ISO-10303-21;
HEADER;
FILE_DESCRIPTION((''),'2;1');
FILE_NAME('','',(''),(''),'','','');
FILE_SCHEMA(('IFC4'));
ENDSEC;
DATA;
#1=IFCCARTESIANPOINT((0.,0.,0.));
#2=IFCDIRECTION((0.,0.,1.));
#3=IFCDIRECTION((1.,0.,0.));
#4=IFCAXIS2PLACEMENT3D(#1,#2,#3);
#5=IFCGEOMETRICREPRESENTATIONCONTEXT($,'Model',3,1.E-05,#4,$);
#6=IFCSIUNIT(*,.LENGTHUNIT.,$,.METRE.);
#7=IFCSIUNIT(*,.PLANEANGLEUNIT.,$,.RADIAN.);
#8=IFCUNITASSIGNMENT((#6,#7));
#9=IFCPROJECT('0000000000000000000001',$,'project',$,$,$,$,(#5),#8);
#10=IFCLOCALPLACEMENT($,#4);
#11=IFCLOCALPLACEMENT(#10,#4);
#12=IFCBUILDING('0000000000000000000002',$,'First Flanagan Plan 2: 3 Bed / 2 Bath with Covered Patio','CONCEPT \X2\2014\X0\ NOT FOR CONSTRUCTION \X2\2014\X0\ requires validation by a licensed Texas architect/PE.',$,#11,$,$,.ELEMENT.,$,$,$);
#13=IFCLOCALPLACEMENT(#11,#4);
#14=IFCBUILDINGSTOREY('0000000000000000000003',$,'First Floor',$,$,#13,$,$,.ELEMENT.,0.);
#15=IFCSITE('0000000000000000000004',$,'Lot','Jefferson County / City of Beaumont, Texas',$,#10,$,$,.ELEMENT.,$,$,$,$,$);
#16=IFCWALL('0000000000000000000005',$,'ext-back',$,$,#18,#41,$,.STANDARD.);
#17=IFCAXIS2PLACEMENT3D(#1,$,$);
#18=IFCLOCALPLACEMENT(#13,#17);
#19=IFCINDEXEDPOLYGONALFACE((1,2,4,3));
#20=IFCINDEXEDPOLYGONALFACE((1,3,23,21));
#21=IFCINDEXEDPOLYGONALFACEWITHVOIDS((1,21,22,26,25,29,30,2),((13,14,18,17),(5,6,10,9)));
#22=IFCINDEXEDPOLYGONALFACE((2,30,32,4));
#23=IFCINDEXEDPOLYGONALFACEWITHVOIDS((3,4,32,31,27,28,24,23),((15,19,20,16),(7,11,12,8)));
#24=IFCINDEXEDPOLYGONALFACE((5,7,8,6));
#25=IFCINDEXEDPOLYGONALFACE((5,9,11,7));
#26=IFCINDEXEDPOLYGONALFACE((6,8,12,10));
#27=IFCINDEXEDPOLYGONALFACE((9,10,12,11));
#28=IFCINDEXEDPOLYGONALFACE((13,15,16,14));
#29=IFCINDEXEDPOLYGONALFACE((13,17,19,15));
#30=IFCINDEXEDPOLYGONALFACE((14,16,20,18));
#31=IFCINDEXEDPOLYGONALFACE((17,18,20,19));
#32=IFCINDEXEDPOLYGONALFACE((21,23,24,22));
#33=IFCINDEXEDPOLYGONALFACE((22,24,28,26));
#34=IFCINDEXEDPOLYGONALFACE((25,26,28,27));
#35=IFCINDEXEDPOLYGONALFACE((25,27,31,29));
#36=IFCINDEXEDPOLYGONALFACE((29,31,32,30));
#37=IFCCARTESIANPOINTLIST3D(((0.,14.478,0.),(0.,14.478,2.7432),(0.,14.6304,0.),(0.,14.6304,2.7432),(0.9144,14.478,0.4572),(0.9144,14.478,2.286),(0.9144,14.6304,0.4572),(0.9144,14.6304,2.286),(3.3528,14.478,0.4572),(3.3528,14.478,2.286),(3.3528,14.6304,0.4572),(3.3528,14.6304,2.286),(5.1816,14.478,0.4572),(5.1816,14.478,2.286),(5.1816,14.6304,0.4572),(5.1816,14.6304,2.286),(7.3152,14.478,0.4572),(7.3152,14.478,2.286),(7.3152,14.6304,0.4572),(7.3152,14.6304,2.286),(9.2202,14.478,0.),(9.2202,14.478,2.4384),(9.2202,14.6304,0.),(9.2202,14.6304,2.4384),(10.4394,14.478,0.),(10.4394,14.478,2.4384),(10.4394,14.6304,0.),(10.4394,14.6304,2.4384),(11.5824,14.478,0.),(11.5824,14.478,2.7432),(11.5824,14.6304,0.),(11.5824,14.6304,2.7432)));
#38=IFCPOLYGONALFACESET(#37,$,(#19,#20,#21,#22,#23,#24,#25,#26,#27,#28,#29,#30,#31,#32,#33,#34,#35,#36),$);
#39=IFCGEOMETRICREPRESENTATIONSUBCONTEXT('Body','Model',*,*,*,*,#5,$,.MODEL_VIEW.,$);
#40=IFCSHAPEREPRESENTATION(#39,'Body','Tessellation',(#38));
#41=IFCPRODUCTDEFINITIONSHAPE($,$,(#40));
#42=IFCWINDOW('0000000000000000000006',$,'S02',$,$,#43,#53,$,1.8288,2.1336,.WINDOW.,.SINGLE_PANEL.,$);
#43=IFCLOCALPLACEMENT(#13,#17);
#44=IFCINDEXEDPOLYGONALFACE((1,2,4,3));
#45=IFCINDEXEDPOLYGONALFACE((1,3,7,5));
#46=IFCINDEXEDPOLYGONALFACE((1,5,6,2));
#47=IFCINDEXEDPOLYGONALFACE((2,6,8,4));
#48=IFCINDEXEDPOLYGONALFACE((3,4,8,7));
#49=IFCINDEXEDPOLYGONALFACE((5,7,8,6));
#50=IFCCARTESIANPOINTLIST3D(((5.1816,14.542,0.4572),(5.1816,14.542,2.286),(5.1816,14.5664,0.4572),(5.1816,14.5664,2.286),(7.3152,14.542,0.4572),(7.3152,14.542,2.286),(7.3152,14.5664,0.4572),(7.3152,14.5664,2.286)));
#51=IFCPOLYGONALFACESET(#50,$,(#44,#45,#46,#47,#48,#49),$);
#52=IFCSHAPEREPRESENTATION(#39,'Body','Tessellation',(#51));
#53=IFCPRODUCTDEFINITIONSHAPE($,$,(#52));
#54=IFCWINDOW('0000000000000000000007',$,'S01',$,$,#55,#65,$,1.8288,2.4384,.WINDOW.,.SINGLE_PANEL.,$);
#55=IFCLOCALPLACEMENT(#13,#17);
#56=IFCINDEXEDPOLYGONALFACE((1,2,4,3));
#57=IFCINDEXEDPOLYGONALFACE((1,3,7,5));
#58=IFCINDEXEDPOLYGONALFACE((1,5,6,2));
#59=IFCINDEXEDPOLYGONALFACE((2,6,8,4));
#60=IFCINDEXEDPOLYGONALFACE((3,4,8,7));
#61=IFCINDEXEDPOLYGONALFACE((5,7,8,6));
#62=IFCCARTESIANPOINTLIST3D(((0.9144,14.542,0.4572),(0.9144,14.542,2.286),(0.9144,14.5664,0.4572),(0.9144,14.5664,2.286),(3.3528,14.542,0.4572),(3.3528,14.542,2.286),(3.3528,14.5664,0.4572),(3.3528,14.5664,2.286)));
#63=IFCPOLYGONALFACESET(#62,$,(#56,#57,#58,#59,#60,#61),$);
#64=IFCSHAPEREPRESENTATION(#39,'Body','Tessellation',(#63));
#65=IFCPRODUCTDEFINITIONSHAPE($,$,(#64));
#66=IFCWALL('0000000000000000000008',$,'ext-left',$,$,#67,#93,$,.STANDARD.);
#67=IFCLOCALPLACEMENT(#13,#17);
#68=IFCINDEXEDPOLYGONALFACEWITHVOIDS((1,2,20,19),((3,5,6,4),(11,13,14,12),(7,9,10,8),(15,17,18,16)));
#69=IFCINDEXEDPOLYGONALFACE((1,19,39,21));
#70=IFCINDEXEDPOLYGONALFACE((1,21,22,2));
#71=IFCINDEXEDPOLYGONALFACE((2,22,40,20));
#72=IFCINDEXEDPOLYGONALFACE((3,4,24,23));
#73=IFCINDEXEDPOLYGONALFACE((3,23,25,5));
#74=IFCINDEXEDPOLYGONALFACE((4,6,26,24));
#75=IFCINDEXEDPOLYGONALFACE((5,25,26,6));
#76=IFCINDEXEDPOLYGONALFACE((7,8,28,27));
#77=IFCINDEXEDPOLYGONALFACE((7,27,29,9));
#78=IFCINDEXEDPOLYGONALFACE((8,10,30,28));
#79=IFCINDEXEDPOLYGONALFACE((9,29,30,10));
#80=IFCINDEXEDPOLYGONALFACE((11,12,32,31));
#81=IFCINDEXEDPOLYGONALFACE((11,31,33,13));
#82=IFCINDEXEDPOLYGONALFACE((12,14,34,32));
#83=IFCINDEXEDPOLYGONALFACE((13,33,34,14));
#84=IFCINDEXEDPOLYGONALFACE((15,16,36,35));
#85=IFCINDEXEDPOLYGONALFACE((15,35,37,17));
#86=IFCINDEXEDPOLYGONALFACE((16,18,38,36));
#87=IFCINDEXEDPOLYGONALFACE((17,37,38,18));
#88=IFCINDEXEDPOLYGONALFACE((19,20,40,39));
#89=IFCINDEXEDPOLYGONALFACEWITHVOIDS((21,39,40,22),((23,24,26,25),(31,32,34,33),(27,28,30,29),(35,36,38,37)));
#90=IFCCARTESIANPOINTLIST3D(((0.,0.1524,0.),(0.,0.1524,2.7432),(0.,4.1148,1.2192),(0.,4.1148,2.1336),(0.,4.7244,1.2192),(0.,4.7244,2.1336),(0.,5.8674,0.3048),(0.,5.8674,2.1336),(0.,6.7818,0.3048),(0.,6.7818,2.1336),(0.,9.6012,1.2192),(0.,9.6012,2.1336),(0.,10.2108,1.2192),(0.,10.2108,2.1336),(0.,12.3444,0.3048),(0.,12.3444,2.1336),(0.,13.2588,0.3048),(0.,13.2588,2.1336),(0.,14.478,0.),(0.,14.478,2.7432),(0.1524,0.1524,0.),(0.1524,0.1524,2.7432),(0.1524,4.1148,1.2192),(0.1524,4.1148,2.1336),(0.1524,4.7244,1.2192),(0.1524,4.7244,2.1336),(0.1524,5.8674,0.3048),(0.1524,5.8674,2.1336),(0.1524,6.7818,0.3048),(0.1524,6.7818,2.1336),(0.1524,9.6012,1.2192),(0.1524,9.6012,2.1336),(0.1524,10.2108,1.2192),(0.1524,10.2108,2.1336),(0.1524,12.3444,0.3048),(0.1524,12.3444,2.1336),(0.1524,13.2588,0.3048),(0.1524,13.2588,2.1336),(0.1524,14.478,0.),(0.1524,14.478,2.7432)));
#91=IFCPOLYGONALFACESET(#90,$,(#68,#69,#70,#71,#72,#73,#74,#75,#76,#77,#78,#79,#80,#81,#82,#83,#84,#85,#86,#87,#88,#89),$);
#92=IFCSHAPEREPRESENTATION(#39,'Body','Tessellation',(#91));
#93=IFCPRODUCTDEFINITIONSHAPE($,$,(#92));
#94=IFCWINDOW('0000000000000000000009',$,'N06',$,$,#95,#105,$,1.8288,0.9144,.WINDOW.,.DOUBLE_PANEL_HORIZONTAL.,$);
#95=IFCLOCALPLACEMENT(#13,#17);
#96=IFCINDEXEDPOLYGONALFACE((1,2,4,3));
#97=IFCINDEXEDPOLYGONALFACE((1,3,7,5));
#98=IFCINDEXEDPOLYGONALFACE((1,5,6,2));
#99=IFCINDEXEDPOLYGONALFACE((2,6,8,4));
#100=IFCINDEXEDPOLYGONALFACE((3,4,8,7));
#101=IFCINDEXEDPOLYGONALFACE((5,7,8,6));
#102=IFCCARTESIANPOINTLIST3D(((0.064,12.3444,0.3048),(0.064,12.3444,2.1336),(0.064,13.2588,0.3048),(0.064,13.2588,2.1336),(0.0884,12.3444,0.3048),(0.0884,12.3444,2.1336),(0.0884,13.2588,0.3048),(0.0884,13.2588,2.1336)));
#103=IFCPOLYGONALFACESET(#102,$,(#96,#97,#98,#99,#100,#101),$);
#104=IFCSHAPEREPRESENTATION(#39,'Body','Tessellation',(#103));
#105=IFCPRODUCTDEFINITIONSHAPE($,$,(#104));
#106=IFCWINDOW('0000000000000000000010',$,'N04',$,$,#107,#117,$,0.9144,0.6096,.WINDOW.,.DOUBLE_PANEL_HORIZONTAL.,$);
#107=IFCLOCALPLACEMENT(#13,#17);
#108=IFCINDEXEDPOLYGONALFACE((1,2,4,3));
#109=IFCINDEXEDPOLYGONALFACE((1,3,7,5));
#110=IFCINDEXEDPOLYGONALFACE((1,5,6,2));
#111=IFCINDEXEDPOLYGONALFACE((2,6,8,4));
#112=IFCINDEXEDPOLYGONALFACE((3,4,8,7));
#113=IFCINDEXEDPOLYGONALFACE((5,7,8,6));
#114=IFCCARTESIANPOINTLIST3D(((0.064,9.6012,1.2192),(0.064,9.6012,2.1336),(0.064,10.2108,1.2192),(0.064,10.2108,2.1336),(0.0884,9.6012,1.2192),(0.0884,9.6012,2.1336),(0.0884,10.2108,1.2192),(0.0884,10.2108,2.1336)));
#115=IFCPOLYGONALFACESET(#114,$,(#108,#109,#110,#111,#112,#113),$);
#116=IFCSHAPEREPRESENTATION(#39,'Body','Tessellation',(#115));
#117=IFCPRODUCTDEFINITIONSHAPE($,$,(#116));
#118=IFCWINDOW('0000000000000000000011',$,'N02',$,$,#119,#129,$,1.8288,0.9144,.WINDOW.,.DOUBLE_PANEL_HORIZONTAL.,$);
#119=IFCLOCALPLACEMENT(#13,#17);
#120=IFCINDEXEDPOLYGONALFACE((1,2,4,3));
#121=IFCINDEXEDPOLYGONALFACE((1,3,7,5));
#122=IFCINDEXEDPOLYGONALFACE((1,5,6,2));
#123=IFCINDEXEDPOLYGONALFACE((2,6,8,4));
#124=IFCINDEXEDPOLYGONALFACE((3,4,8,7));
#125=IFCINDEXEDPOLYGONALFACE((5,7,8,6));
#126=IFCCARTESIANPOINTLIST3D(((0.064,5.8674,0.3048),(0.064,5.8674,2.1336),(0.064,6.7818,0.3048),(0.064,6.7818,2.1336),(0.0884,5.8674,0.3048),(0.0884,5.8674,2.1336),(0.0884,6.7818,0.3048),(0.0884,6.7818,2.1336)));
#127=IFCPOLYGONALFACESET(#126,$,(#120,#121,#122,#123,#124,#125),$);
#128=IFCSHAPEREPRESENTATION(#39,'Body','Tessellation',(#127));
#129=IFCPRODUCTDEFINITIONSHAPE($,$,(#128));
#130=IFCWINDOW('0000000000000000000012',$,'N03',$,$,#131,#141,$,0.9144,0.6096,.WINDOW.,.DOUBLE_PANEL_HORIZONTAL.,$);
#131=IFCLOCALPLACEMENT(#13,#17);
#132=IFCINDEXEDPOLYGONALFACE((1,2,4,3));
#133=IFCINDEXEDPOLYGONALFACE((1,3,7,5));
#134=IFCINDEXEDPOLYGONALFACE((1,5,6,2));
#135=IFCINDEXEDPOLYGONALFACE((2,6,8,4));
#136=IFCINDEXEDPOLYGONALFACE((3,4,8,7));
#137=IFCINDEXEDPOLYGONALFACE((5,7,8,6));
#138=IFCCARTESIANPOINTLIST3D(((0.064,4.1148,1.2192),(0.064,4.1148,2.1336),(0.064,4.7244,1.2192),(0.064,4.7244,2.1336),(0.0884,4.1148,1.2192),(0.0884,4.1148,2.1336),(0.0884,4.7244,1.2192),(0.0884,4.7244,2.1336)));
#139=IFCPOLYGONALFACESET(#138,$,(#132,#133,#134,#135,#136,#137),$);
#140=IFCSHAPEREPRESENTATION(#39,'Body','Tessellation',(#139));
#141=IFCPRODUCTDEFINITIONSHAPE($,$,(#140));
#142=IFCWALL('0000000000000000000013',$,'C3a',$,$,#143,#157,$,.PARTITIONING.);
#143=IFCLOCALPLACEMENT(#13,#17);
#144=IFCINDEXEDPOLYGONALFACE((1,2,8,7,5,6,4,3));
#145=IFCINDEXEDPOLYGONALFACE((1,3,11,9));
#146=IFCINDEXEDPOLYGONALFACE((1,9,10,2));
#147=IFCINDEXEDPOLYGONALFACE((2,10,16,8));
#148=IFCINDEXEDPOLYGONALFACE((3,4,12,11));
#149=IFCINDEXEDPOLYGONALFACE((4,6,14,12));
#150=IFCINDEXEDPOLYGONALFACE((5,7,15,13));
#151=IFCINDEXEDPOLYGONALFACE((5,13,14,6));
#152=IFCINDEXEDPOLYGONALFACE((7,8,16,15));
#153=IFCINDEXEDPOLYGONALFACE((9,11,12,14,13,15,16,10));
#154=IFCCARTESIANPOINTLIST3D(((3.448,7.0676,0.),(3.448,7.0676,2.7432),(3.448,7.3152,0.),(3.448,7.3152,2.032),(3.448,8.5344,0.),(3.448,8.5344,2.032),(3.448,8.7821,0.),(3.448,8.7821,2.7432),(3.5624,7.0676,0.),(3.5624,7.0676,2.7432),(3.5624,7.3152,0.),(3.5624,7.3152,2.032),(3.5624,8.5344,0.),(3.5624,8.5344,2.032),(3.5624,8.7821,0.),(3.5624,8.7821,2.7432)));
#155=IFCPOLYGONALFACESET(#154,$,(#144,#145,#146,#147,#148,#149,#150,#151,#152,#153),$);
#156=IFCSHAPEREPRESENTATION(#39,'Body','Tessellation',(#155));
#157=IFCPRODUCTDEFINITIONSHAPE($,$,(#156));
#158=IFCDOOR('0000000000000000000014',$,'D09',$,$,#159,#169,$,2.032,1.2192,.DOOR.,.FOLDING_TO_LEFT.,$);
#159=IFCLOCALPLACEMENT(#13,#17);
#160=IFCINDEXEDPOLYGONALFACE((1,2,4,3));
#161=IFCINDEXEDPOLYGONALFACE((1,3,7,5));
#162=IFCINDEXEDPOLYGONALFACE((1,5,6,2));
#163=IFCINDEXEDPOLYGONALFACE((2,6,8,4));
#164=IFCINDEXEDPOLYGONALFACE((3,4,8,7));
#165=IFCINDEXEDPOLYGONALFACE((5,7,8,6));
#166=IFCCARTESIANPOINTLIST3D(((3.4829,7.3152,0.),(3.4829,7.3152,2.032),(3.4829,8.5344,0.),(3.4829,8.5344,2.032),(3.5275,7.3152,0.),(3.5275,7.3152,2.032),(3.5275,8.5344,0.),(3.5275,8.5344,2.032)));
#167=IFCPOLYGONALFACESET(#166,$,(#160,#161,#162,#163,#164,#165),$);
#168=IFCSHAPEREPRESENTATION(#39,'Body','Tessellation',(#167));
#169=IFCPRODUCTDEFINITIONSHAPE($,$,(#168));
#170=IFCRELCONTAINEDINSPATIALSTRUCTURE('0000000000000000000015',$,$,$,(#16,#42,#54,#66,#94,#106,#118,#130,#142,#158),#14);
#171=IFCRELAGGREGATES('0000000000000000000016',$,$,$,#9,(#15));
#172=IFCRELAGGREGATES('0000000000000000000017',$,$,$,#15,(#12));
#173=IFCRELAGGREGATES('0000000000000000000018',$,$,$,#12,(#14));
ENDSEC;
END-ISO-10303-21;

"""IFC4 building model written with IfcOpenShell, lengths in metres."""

from ifc_helpers import new_model, si_unit, frame, frame_2d, origin_with_axes, place, context, subcontext, project, spatial, rectangle, extrude, element, fill, save


model = new_model("IFC4")

# Units and contexts
model_context = context("Model", 3, precision=1e-05, world=origin_with_axes())
body_context = subcontext(model_context, "Body", "Model", "MODEL_VIEW")
ifc_project = project(units=[si_unit("LENGTHUNIT", "METRE"), si_unit("PLANEANGLEUNIT", "RADIAN")], contexts=[model_context])

# Site, building, storey
site_placement = place(None, origin_with_axes())
site = spatial("IfcSite", under=ifc_project, at=site_placement, Name="Lot", Description="Jefferson County / City of Beaumont, Texas", CompositionType="ELEMENT")
building_placement = place(site_placement, origin_with_axes())
building = spatial("IfcBuilding", under=site, at=building_placement, Name="First Flanagan Plan 2: 3 Bed / 2 Bath with Covered Patio", Description="CONCEPT — NOT FOR CONSTRUCTION — requires validation by a licensed Texas architect/PE.", CompositionType="ELEMENT")
storey_placement = place(building_placement, origin_with_axes())
storey = spatial("IfcBuildingStorey", under=building, at=storey_placement, Name="First Floor", CompositionType="ELEMENT", Elevation=0.0)

# Walls, openings, windows
wall_1_placement = place(storey_placement, frame((11.5824, 14.5542, 0.0), z_axis=(0.0, 0.0, 1.0), x_axis=(-1.0, 0.0, 0.0)))
wall_1 = element("IfcWall", 1, at=wall_1_placement, inside=storey, Name="ext-back", PredefinedType="STANDARD", context=body_context, shape_type="SweptSolid", body=[
    extrude(rectangle(XDim=11.5824, YDim=0.1524, at=frame_2d((5.7912, 0.0), x_axis=(1.0, 0.0))), origin_with_axes(), (0.0, 0.0, 1.0), 2.7432),
])
opening_1_placement = place(wall_1_placement, frame((1.143, 0.0, 0.0), z_axis=(0.0, 0.0, 1.0), x_axis=(1.0, 0.0, 0.0)))
element("IfcOpeningElement", 2, at=opening_1_placement, cuts=wall_1, PredefinedType="OPENING", context=body_context, shape_type="SweptSolid", body=[
    extrude(rectangle(XDim=1.2192, YDim=0.1829, at=frame_2d((0.6096, 0.0), x_axis=(1.0, 0.0))), origin_with_axes(), (0.0, 0.0, 1.0), 2.4384),
])
opening_2_placement = place(wall_1_placement, frame((4.2672, 0.0, 0.4572), z_axis=(0.0, 0.0, 1.0), x_axis=(1.0, 0.0, 0.0)))
opening_2 = element("IfcOpeningElement", 3, at=opening_2_placement, cuts=wall_1, PredefinedType="OPENING", context=body_context, shape_type="SweptSolid", body=[
    extrude(rectangle(XDim=2.1336, YDim=0.1829, at=frame_2d((1.0668, 0.0), x_axis=(1.0, 0.0))), origin_with_axes(), (0.0, 0.0, 1.0), 1.8288),
])
opening_3_placement = place(wall_1_placement, frame((8.2296, 0.0, 0.4572), z_axis=(0.0, 0.0, 1.0), x_axis=(1.0, 0.0, 0.0)))
opening_3 = element("IfcOpeningElement", 4, at=opening_3_placement, cuts=wall_1, PredefinedType="OPENING", context=body_context, shape_type="SweptSolid", body=[
    extrude(rectangle(XDim=2.4384, YDim=0.1829, at=frame_2d((1.2192, 0.0), x_axis=(1.0, 0.0))), origin_with_axes(), (0.0, 0.0, 1.0), 1.8288),
])
window_1_placement = place(opening_2_placement, origin_with_axes())
window_1 = element("IfcWindow", 5, at=window_1_placement, inside=storey, Name="S02", OverallHeight=1.8288, OverallWidth=2.1336, PartitioningType="SINGLE_PANEL", PredefinedType="WINDOW", context=body_context, shape_type="SweptSolid", body=[
    extrude(rectangle(XDim=2.1336, YDim=0.0244, at=frame_2d((1.0668, 0.0), x_axis=(1.0, 0.0))), origin_with_axes(), (0.0, 0.0, 1.0), 1.8288),
])
fill(opening_2, window_1)
window_2_placement = place(opening_3_placement, origin_with_axes())
window_2 = element("IfcWindow", 6, at=window_2_placement, inside=storey, Name="S01", OverallHeight=1.8288, OverallWidth=2.4384, PartitioningType="SINGLE_PANEL", PredefinedType="WINDOW", context=body_context, shape_type="SweptSolid", body=[
    extrude(rectangle(XDim=2.4384, YDim=0.0244, at=frame_2d((1.2192, 0.0), x_axis=(1.0, 0.0))), origin_with_axes(), (0.0, 0.0, 1.0), 1.8288),
])
fill(opening_3, window_2)
wall_2_placement = place(storey_placement, frame((0.0762, 14.478, 0.0), z_axis=(0.0, 0.0, 1.0), x_axis=(0.0, -1.0, 0.0)))
wall_2 = element("IfcWall", 7, at=wall_2_placement, inside=storey, Name="ext-left", PredefinedType="STANDARD", context=body_context, shape_type="SweptSolid", body=[
    extrude(rectangle(XDim=14.3256, YDim=0.1524, at=frame_2d((7.1628, 0.0), x_axis=(1.0, 0.0))), origin_with_axes(), (0.0, 0.0, 1.0), 2.7432),
])
opening_4_placement = place(wall_2_placement, frame((1.2192, 0.0, 0.3048), z_axis=(0.0, 0.0, 1.0), x_axis=(1.0, 0.0, 0.0)))
opening_4 = element("IfcOpeningElement", 8, at=opening_4_placement, cuts=wall_2, PredefinedType="OPENING", context=body_context, shape_type="SweptSolid", body=[
    extrude(rectangle(XDim=0.9144, YDim=0.1829, at=frame_2d((0.4572, 0.0), x_axis=(1.0, 0.0))), origin_with_axes(), (0.0, 0.0, 1.0), 1.8288),
])
opening_5_placement = place(wall_2_placement, frame((4.2672, 0.0, 1.2192), z_axis=(0.0, 0.0, 1.0), x_axis=(1.0, 0.0, 0.0)))
opening_5 = element("IfcOpeningElement", 9, at=opening_5_placement, cuts=wall_2, PredefinedType="OPENING", context=body_context, shape_type="SweptSolid", body=[
    extrude(rectangle(XDim=0.6096, YDim=0.1829, at=frame_2d((0.3048, 0.0), x_axis=(1.0, 0.0))), origin_with_axes(), (0.0, 0.0, 1.0), 0.9144),
])
opening_6_placement = place(wall_2_placement, frame((7.6962, 0.0, 0.3048), z_axis=(0.0, 0.0, 1.0), x_axis=(1.0, 0.0, 0.0)))
opening_6 = element("IfcOpeningElement", 10, at=opening_6_placement, cuts=wall_2, PredefinedType="OPENING", context=body_context, shape_type="SweptSolid", body=[
    extrude(rectangle(XDim=0.9144, YDim=0.1829, at=frame_2d((0.4572, 0.0), x_axis=(1.0, 0.0))), origin_with_axes(), (0.0, 0.0, 1.0), 1.8288),
])
opening_7_placement = place(wall_2_placement, frame((9.7536, 0.0, 1.2192), z_axis=(0.0, 0.0, 1.0), x_axis=(1.0, 0.0, 0.0)))
opening_7 = element("IfcOpeningElement", 11, at=opening_7_placement, cuts=wall_2, PredefinedType="OPENING", context=body_context, shape_type="SweptSolid", body=[
    extrude(rectangle(XDim=0.6096, YDim=0.1829, at=frame_2d((0.3048, 0.0), x_axis=(1.0, 0.0))), origin_with_axes(), (0.0, 0.0, 1.0), 0.9144),
])
window_3_placement = place(opening_4_placement, origin_with_axes())
window_3 = element("IfcWindow", 12, at=window_3_placement, inside=storey, Name="N06", OverallHeight=1.8288, OverallWidth=0.9144, PartitioningType="DOUBLE_PANEL_HORIZONTAL", PredefinedType="WINDOW", context=body_context, shape_type="SweptSolid", body=[
    extrude(rectangle(XDim=0.9144, YDim=0.0244, at=frame_2d((0.4572, 0.0), x_axis=(1.0, 0.0))), origin_with_axes(), (0.0, 0.0, 1.0), 1.8288),
])
fill(opening_4, window_3)
window_4_placement = place(opening_5_placement, origin_with_axes())
window_4 = element("IfcWindow", 13, at=window_4_placement, inside=storey, Name="N04", OverallHeight=0.9144, OverallWidth=0.6096, PartitioningType="DOUBLE_PANEL_HORIZONTAL", PredefinedType="WINDOW", context=body_context, shape_type="SweptSolid", body=[
    extrude(rectangle(XDim=0.6096, YDim=0.0244, at=frame_2d((0.3048, 0.0), x_axis=(1.0, 0.0))), origin_with_axes(), (0.0, 0.0, 1.0), 0.9144),
])
fill(opening_5, window_4)
window_5_placement = place(opening_6_placement, origin_with_axes())
window_5 = element("IfcWindow", 14, at=window_5_placement, inside=storey, Name="N02", OverallHeight=1.8288, OverallWidth=0.9144, PartitioningType="DOUBLE_PANEL_HORIZONTAL", PredefinedType="WINDOW", context=body_context, shape_type="SweptSolid", body=[
    extrude(rectangle(XDim=0.9144, YDim=0.0244, at=frame_2d((0.4572, 0.0), x_axis=(1.0, 0.0))), origin_with_axes(), (0.0, 0.0, 1.0), 1.8288),
])
fill(opening_6, window_5)
window_6_placement = place(opening_7_placement, origin_with_axes())
window_6 = element("IfcWindow", 15, at=window_6_placement, inside=storey, Name="N03", OverallHeight=0.9144, OverallWidth=0.6096, PartitioningType="DOUBLE_PANEL_HORIZONTAL", PredefinedType="WINDOW", context=body_context, shape_type="SweptSolid", body=[
    extrude(rectangle(XDim=0.6096, YDim=0.0244, at=frame_2d((0.3048, 0.0), x_axis=(1.0, 0.0))), origin_with_axes(), (0.0, 0.0, 1.0), 0.9144),
])
fill(opening_7, window_6)

# Wall, opening, door
wall_3_placement = place(storey_placement, frame((3.5052, 7.0676, 0.0), z_axis=(0.0, 0.0, 1.0), x_axis=(0.0, 1.0, 0.0)))
wall_3 = element("IfcWall", 16, at=wall_3_placement, inside=storey, Name="C3a", PredefinedType="PARTITIONING", context=body_context, shape_type="SweptSolid", body=[
    extrude(rectangle(XDim=1.7145, YDim=0.1143, at=frame_2d((0.8573, 0.0), x_axis=(1.0, 0.0))), origin_with_axes(), (0.0, 0.0, 1.0), 2.7432),
])
opening_8_placement = place(wall_3_placement, frame((0.2477, 0.0, 0.0), z_axis=(0.0, 0.0, 1.0), x_axis=(1.0, 0.0, 0.0)))
opening_8 = element("IfcOpeningElement", 17, at=opening_8_placement, cuts=wall_3, PredefinedType="OPENING", context=body_context, shape_type="SweptSolid", body=[
    extrude(rectangle(XDim=1.2192, YDim=0.1448, at=frame_2d((0.6096, 0.0), x_axis=(1.0, 0.0))), origin_with_axes(), (0.0, 0.0, 1.0), 2.032),
])
door_1_placement = place(opening_8_placement, origin_with_axes())
door_1 = element("IfcDoor", 18, at=door_1_placement, inside=storey, Name="D09", OperationType="FOLDING_TO_LEFT", OverallHeight=2.032, OverallWidth=1.2192, PredefinedType="DOOR", context=body_context, shape_type="SweptSolid", body=[
    extrude(rectangle(XDim=1.2192, YDim=0.0445, at=frame_2d((0.6096, 0.0), x_axis=(1.0, 0.0))), origin_with_axes(), (0.0, 0.0, 1.0), 2.032),
])
fill(opening_8, door_1)

save(model, "model.ifc")
